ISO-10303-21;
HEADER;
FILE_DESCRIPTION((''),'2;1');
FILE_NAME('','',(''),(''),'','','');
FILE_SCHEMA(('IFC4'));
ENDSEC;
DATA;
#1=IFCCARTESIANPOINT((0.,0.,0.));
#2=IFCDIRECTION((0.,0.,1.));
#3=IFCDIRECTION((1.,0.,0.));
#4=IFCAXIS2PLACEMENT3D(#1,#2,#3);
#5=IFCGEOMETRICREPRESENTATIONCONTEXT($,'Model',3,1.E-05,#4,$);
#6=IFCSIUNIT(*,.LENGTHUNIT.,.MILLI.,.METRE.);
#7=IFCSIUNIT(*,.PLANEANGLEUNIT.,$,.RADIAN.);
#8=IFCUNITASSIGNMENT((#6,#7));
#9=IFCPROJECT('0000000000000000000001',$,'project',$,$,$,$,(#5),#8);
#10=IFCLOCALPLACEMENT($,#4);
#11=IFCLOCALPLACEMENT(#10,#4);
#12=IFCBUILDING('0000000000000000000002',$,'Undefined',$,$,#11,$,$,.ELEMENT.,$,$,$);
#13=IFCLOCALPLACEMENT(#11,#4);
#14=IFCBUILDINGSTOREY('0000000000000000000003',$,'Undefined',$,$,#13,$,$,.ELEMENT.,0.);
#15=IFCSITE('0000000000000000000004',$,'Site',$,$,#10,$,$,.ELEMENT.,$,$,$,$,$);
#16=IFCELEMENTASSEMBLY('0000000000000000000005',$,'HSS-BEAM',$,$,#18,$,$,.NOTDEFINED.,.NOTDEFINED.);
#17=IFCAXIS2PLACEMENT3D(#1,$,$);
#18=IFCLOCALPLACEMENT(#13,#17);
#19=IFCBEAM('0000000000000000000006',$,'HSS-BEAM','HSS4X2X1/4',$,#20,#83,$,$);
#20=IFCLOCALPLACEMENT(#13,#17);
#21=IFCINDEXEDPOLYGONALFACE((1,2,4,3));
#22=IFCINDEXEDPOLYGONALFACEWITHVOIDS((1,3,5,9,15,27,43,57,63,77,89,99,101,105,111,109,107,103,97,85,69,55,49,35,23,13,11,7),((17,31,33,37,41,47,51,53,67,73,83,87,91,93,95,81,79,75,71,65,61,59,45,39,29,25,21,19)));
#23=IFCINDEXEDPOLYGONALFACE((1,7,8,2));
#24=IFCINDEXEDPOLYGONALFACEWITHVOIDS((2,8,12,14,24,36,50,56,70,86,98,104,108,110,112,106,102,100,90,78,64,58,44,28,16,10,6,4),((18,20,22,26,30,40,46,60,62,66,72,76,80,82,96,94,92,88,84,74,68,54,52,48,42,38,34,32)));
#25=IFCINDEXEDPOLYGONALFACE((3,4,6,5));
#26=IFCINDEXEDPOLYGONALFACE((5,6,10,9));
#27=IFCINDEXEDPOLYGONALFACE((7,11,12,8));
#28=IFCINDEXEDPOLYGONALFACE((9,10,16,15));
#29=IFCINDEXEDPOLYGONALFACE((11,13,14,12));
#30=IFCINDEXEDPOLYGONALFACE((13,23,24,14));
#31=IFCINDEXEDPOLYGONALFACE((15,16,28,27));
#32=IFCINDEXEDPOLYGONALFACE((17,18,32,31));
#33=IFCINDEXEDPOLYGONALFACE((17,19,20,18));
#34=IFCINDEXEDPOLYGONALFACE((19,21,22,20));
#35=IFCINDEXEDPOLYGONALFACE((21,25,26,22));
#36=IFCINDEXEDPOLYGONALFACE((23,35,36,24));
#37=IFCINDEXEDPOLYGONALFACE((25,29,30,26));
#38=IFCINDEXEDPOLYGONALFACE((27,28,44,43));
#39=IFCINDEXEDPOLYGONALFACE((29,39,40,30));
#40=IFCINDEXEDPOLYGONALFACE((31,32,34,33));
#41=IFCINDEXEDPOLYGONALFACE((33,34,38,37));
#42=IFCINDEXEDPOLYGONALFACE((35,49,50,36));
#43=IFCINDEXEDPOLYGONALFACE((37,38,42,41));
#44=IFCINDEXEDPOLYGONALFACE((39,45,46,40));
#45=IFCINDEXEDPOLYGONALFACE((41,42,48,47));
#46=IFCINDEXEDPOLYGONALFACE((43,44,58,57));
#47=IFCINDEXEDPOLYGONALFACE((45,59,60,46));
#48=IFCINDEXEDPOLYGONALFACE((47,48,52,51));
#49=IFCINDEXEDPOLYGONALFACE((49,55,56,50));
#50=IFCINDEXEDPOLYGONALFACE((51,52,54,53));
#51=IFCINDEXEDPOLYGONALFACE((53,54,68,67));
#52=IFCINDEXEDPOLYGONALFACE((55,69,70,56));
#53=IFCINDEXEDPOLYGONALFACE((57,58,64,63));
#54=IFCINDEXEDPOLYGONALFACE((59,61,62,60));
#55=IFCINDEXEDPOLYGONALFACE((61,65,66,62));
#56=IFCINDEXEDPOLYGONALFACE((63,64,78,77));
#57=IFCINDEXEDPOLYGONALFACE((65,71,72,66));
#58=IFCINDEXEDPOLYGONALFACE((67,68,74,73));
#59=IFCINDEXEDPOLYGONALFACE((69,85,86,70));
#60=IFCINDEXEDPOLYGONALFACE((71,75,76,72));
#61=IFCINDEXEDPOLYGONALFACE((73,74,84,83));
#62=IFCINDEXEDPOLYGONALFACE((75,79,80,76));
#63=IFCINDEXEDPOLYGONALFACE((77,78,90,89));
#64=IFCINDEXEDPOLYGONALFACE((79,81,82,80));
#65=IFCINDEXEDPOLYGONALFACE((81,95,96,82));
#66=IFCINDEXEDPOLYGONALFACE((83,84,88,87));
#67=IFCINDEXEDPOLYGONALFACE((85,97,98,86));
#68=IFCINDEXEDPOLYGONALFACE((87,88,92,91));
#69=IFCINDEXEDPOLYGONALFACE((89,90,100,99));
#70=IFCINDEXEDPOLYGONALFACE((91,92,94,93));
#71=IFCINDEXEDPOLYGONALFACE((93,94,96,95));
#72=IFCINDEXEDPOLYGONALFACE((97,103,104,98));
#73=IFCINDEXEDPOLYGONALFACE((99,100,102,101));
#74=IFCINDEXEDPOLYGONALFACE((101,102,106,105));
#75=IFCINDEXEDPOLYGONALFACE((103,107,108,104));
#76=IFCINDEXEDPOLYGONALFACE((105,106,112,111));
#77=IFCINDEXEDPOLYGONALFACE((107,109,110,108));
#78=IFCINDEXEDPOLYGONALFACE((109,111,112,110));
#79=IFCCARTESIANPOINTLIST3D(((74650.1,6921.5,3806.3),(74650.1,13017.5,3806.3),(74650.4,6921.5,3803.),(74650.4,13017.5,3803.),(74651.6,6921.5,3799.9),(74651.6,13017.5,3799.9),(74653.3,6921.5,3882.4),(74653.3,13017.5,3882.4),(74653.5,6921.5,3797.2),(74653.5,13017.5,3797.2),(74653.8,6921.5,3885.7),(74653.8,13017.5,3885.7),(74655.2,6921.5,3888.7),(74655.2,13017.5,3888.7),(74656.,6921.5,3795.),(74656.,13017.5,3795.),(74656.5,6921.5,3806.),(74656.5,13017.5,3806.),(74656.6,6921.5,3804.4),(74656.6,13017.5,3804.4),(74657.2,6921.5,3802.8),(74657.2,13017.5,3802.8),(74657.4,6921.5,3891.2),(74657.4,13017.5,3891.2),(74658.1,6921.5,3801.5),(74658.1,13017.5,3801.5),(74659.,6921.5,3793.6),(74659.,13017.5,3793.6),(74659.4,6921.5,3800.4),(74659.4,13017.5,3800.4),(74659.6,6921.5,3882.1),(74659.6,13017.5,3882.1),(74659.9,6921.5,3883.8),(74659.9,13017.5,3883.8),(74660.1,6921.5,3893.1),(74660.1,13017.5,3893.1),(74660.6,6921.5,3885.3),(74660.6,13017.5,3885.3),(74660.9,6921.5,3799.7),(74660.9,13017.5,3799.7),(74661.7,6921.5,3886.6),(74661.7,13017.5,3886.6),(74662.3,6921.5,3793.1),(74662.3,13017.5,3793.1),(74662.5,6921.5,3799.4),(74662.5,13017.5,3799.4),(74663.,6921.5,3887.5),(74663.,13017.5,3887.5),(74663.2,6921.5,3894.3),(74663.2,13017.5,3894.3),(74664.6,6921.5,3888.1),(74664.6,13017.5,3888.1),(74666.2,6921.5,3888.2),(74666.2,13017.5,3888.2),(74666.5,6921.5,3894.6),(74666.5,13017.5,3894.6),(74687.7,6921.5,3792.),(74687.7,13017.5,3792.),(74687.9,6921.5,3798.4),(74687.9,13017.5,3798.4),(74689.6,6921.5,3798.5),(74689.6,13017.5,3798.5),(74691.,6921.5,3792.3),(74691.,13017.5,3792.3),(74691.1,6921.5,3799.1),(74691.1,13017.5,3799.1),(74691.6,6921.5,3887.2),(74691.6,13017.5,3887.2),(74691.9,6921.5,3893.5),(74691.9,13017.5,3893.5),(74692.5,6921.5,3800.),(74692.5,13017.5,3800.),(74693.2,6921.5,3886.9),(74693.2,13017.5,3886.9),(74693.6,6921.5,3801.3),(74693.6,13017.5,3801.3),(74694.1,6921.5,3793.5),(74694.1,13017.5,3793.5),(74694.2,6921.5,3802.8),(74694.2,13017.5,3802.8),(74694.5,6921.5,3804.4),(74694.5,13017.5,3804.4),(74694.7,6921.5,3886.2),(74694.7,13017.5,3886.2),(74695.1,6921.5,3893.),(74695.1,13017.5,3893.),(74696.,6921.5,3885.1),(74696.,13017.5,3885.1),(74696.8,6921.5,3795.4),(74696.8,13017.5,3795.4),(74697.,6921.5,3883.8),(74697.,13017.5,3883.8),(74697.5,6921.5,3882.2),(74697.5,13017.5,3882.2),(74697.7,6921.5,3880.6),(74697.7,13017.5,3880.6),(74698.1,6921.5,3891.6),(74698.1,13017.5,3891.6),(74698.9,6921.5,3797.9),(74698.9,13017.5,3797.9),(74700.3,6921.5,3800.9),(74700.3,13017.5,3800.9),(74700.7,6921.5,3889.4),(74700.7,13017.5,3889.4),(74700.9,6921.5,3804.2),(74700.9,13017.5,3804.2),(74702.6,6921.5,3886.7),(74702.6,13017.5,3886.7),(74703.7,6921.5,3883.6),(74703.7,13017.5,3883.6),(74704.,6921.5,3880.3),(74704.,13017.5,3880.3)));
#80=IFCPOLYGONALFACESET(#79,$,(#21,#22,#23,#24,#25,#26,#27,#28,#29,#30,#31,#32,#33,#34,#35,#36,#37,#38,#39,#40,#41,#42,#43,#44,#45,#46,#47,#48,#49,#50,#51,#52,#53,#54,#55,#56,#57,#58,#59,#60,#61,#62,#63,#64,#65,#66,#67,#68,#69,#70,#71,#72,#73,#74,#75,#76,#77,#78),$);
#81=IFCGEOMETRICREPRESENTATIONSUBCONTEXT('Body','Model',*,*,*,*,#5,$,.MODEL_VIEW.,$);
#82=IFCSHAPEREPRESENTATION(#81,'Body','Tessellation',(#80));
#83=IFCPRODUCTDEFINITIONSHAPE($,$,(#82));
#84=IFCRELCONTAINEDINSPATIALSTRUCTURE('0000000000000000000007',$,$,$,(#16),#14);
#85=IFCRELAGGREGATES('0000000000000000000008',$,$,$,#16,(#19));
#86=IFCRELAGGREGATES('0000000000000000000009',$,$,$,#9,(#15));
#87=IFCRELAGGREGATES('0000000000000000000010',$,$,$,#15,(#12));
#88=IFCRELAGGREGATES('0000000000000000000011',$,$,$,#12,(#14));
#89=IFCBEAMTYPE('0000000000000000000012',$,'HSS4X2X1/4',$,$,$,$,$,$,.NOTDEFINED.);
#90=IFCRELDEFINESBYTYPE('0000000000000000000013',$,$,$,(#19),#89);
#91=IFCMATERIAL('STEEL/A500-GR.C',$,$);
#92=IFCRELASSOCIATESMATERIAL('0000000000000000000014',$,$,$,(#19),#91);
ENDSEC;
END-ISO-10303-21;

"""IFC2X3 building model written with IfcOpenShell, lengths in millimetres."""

from ifc_helpers import new_model, si_unit, frame, origin_with_axes, origin_2d_with_axis, place, context, subcontext, project, spatial, hollow_rectangle, extrude, material, type_object, element, aggregate, save


model = new_model("IFC2X3")

# Units and contexts
model_context = context("Model", 3, precision=1e-05, world=origin_with_axes())
body_context = subcontext(model_context, "Body", "Model", "MODEL_VIEW")
ifc_project = project(units=[si_unit("LENGTHUNIT", "METRE", prefix="MILLI"), si_unit("PLANEANGLEUNIT", "RADIAN")], contexts=[model_context])

# Site, building, storey
site_placement = place(None, origin_with_axes())
site = spatial("IfcSite", under=ifc_project, at=site_placement, Name="Site", CompositionType="ELEMENT")
building_placement = place(site_placement, origin_with_axes())
building = spatial("IfcBuilding", under=site, at=building_placement, Name="Undefined", CompositionType="ELEMENT")
storey_placement = place(building_placement, origin_with_axes())
storey = spatial("IfcBuildingStorey", under=building, at=storey_placement, Name="Undefined", CompositionType="ELEMENT", Elevation=0.0)

# Element assembly, beam
ifc_material_1 = material(Name="STEEL/A500-GR.C")
beam_type_1 = type_object("IfcBeamType", Name="HSS4X2X1/4", PredefinedType="NOTDEFINED")
assembly_1_placement = place(storey_placement, origin_with_axes())
assembly_1 = element("IfcElementAssembly", 1, at=assembly_1_placement, inside=storey, Name="HSS-BEAM", AssemblyPlace="NOTDEFINED", PredefinedType="NOTDEFINED")
beam_1_placement = place(assembly_1_placement, frame((74677.1, 6921.5, 3843.3), z_axis=(0.041337, 0.0, 0.999145), x_axis=(0.0, 1.0, 0.0)))
beam_1 = element("IfcBeam", 2, at=beam_1_placement, type_object=beam_type_1, material=ifc_material_1, Name="HSS-BEAM", Description="HSS4X2X1/4", context=body_context, shape_type="SweptSolid", body=[
    extrude(hollow_rectangle(XDim=50.8, YDim=101.6, WallThickness=6.3, InnerFilletRadius=6.3, OuterFilletRadius=12.7, at=origin_2d_with_axis()), frame((6096.0, 0.0, 0.0), z_axis=(-1.0, 0.0, 0.0), x_axis=(0.0, -1.0, 0.0)), (0.0, 0.0, 1.0), 6096.0),
])

aggregate(assembly_1, [beam_1])

save(model, "model.ifc")
